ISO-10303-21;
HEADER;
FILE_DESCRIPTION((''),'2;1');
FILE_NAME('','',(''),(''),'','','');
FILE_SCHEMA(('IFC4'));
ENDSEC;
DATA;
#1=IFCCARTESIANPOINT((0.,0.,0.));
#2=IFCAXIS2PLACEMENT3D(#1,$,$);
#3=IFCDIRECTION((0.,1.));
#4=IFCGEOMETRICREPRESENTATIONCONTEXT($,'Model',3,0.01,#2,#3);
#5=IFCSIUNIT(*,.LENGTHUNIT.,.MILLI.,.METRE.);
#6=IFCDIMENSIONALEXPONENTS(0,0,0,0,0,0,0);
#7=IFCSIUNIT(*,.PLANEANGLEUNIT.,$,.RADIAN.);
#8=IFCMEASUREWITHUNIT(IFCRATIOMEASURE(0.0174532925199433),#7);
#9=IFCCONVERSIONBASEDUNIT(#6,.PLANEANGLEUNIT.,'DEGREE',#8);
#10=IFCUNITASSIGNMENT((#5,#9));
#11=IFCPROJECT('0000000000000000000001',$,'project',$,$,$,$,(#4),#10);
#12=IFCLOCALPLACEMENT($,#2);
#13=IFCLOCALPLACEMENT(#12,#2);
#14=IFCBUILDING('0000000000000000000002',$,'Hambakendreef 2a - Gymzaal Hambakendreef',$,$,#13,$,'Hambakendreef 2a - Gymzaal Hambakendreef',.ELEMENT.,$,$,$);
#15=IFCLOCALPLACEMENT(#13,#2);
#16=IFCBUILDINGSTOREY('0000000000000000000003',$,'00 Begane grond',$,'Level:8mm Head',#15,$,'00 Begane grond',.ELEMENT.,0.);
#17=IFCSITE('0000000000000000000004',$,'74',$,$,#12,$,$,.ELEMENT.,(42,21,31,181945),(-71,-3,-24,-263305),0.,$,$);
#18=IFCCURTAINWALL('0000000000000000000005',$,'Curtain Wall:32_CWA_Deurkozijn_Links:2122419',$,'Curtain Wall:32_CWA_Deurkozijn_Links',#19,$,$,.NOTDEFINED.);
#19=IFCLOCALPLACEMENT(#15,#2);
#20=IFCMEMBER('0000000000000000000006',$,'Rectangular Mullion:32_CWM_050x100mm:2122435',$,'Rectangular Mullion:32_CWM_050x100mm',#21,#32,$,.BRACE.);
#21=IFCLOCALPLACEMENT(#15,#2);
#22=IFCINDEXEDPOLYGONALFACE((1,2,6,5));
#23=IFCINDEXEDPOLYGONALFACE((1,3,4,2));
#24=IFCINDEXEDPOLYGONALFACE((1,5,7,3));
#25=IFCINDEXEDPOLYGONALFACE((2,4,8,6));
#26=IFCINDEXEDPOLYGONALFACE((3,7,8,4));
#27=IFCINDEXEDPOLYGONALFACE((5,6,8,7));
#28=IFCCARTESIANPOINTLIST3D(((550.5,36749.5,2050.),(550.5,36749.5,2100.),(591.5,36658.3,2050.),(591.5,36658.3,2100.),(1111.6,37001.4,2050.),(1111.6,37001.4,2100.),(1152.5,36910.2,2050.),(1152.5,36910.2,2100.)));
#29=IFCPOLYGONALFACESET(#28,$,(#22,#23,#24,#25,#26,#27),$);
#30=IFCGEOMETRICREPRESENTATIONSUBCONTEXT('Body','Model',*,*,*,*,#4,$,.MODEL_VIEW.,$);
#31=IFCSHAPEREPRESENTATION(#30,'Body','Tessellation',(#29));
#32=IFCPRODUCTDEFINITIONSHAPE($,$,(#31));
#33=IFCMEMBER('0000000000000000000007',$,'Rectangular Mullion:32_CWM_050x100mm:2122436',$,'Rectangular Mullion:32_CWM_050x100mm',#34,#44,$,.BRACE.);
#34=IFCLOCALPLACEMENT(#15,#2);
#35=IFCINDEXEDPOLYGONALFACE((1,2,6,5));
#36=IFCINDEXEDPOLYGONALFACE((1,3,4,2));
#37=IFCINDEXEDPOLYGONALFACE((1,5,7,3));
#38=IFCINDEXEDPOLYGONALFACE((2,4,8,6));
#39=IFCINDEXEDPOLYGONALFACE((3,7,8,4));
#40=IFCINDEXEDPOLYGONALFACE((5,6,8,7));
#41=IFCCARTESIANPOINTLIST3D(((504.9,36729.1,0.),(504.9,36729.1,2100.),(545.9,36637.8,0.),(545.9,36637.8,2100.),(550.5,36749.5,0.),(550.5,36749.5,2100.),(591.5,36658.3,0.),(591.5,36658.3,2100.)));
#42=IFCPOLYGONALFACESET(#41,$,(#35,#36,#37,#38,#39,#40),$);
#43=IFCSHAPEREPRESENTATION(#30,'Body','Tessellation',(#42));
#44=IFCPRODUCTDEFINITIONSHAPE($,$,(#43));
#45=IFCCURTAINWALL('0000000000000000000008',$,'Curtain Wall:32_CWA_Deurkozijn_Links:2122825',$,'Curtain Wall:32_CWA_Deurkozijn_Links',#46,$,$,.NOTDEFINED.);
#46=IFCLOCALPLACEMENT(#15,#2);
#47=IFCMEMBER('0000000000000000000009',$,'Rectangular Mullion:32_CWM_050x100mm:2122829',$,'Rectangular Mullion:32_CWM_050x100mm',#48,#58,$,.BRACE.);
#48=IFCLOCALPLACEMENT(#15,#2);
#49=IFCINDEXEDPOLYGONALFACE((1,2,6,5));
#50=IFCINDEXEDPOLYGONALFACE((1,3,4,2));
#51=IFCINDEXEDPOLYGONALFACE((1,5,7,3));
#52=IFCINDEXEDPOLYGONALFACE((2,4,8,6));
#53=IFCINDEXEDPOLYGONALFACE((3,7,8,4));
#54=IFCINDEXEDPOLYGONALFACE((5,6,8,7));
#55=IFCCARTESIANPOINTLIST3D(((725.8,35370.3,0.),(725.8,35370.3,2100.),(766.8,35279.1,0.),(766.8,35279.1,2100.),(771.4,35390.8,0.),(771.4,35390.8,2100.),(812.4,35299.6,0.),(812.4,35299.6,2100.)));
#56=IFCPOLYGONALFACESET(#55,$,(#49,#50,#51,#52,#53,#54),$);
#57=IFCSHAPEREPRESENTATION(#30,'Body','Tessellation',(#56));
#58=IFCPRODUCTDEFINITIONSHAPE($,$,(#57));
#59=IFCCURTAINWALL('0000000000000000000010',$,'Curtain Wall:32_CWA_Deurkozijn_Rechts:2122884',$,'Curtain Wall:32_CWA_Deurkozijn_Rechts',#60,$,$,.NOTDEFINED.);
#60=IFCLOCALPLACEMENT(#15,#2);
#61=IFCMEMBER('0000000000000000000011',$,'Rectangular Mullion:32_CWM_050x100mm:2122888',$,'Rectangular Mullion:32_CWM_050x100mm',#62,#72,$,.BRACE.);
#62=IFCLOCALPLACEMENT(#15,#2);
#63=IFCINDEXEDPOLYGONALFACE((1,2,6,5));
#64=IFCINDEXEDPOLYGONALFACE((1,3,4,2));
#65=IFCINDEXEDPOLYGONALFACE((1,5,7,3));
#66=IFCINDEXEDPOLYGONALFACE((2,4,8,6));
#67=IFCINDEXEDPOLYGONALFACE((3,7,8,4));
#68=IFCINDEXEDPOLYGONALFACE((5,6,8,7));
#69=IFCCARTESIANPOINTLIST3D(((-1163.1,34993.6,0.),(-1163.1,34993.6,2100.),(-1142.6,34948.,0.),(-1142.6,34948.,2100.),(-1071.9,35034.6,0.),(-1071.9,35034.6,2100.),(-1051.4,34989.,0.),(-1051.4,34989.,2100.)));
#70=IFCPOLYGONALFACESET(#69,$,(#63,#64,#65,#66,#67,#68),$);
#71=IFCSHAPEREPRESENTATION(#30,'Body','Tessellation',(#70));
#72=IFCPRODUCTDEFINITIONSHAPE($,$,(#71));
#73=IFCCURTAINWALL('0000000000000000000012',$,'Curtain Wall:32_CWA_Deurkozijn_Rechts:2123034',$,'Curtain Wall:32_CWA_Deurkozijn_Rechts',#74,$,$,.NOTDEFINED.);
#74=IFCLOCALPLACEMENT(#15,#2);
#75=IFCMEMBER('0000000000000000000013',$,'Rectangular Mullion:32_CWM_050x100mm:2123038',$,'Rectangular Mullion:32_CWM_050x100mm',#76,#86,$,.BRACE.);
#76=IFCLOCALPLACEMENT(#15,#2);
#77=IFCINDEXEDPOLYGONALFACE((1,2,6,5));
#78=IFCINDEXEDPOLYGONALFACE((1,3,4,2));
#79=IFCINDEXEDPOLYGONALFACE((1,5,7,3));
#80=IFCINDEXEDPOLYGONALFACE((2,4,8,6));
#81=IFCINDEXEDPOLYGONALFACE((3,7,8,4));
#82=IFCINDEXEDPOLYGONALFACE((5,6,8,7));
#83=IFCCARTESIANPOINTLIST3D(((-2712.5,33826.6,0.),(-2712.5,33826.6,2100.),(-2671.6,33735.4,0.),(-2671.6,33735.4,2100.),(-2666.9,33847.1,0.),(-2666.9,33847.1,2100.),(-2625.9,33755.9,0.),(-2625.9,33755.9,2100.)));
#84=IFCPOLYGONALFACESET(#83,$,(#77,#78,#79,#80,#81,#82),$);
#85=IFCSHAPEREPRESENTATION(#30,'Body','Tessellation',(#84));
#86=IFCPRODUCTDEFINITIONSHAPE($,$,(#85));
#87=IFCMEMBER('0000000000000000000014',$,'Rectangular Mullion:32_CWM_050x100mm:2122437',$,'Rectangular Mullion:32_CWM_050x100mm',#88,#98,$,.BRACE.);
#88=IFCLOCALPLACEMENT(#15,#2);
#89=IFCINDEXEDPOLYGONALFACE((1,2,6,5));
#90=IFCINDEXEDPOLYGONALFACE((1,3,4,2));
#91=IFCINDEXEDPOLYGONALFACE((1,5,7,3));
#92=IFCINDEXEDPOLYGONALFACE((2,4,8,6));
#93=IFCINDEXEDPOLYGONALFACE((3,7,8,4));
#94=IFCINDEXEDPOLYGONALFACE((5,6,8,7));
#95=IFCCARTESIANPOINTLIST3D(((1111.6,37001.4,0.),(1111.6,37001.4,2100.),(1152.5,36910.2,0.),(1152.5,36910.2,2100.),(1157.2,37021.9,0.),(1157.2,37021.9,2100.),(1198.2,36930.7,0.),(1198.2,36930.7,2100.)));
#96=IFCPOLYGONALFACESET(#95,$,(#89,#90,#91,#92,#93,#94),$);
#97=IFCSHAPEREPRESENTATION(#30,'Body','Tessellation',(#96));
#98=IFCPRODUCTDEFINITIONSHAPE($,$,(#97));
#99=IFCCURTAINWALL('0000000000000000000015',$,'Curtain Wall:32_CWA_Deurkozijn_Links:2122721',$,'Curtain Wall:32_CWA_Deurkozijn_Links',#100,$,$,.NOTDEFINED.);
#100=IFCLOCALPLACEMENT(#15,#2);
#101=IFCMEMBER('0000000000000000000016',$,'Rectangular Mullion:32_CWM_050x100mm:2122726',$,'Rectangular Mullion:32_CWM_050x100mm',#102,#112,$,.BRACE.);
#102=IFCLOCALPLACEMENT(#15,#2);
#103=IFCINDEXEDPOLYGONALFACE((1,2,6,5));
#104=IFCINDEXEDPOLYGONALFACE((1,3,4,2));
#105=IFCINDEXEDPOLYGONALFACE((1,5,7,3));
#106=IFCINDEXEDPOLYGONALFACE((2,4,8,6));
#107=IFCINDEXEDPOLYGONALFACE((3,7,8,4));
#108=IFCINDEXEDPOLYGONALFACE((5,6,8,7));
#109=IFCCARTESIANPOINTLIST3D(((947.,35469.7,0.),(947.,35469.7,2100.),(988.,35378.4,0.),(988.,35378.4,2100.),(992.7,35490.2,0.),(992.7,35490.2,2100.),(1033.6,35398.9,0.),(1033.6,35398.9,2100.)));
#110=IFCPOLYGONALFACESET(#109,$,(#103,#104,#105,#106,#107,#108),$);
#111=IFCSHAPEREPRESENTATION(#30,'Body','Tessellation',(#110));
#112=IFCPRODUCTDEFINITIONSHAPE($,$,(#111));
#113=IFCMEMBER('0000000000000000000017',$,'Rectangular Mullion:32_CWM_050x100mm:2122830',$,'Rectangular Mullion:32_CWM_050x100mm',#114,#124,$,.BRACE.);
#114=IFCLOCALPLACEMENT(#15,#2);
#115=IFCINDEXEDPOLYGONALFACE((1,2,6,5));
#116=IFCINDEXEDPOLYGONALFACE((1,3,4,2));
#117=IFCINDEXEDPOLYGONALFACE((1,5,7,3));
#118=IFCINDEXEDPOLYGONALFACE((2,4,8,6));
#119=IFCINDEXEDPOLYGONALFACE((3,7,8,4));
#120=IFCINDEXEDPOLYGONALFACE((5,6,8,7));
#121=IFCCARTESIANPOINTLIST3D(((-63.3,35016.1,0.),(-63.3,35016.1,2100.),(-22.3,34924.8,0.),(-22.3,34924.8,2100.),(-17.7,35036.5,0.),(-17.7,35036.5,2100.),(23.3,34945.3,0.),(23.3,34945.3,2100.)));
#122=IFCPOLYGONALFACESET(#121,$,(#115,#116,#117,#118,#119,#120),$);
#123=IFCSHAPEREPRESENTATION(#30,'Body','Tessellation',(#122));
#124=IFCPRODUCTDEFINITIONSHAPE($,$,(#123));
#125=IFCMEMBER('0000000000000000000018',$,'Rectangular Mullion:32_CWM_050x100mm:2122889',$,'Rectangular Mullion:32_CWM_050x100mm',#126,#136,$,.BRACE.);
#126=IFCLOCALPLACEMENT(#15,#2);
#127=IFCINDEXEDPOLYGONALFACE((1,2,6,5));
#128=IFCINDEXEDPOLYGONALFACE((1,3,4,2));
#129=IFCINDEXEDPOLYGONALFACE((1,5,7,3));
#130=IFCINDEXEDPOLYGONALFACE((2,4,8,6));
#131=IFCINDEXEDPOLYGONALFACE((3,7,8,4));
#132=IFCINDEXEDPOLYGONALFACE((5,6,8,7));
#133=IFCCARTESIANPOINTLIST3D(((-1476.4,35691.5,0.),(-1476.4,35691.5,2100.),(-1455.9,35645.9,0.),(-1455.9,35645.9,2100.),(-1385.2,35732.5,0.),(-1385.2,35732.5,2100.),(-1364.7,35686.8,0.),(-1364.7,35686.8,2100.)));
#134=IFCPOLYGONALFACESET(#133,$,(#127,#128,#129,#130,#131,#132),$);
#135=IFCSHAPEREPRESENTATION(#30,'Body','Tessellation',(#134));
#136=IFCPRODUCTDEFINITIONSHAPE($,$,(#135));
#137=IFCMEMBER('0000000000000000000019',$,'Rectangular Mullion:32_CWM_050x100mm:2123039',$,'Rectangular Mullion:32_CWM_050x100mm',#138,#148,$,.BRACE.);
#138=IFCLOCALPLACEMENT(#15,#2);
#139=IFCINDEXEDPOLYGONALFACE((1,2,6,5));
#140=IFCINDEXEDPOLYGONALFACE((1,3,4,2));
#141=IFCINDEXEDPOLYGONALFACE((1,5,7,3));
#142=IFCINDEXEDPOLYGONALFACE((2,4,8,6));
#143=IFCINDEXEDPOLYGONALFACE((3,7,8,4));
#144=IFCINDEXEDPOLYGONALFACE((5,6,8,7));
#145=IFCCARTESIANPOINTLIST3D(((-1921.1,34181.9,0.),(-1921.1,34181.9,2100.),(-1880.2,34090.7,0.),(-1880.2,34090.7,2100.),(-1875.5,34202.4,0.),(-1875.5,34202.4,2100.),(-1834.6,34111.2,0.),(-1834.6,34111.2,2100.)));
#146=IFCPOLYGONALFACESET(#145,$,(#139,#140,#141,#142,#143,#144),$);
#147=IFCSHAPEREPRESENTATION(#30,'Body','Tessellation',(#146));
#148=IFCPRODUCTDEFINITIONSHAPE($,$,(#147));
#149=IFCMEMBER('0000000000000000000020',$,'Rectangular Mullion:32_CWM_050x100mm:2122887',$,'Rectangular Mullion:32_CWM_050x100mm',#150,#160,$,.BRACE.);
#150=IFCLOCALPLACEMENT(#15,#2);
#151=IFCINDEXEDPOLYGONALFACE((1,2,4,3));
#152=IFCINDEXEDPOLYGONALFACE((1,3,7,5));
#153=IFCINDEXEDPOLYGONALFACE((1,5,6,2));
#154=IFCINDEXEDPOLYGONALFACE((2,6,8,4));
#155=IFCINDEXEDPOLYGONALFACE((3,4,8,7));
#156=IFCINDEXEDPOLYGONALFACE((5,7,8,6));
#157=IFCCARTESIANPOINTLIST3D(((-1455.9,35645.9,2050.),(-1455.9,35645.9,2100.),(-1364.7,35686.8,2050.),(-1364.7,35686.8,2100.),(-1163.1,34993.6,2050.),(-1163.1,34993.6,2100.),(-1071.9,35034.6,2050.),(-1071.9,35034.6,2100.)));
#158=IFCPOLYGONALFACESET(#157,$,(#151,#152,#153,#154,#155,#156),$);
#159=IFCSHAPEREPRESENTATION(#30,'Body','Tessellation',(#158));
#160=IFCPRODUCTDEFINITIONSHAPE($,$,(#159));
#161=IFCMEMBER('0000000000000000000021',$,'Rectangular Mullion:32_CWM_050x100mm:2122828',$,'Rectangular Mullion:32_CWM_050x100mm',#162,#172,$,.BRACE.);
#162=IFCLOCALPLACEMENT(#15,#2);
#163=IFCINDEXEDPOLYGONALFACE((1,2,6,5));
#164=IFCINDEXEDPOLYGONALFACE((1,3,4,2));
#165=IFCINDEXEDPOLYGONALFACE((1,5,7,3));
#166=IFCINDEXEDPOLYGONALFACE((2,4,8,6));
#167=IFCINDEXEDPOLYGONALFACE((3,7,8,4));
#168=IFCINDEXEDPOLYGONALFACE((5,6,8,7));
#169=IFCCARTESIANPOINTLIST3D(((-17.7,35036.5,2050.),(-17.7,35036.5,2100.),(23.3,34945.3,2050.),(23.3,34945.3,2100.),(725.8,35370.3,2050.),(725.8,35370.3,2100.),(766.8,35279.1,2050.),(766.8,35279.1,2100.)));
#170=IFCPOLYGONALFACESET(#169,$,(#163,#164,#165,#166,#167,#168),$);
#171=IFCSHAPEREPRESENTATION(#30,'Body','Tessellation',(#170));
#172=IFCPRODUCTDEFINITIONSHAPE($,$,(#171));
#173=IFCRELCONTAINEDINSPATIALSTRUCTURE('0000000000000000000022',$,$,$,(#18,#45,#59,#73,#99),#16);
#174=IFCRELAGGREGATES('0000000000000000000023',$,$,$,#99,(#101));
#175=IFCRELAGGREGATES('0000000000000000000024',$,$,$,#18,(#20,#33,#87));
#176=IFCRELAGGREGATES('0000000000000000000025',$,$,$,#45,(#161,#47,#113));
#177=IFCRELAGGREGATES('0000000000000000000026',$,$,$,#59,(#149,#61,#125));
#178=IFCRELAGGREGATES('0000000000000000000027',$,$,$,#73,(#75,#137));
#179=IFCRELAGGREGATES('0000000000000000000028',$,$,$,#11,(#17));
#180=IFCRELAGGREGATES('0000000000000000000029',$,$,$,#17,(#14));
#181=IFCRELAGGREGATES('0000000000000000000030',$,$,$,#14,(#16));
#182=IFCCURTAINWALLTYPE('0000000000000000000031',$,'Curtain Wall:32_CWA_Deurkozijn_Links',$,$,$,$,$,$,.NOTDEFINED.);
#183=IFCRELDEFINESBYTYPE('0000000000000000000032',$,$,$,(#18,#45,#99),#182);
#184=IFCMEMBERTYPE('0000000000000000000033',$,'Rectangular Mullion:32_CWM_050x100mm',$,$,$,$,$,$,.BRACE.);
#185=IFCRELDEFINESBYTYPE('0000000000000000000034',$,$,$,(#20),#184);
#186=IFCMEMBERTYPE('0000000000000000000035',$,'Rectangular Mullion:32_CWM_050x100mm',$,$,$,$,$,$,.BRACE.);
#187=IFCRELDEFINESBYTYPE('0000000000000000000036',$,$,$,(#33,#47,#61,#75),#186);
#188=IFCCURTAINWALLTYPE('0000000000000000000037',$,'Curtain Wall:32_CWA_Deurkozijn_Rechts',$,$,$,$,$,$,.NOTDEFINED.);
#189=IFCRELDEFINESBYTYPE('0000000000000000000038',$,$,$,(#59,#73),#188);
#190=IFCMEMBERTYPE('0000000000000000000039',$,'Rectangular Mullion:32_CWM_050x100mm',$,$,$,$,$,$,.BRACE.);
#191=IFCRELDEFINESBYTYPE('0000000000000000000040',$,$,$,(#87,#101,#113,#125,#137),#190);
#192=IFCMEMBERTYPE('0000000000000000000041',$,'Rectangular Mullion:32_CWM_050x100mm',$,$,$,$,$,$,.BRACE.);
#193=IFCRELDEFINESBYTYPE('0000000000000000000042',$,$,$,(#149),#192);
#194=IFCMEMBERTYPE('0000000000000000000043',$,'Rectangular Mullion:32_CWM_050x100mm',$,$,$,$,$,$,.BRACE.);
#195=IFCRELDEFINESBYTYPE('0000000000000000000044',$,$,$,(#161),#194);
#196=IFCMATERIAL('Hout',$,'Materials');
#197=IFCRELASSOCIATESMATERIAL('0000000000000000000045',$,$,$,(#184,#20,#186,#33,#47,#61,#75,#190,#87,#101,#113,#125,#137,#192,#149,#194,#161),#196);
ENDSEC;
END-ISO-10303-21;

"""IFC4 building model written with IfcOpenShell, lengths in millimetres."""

from ifc_helpers import new_model, entity, si_unit, converted_unit, direction, frame, origin, place, context, subcontext, project, spatial, indexed_curve, outline, extrude, source, transform, mapped, material, type_object, type_shapes, element, aggregate, save


model = new_model("IFC4")

# Units and contexts
model_context = context("Model", 3, precision=0.01, world=origin(), true_north=direction((0.0, 1.0)))
body_context = subcontext(model_context, "Body", "Model", "MODEL_VIEW")
ifc_project = project(units=[si_unit("LENGTHUNIT", "METRE", prefix="MILLI"), converted_unit("PLANEANGLEUNIT", "DEGREE", entity("IfcRatioMeasure", 0.0174532925199433), si_unit("PLANEANGLEUNIT", "RADIAN"), dimensions=[0, 0, 0, 0, 0, 0, 0])], contexts=[model_context])

# Site, building, storey
site_placement = place(None, origin())
site = spatial("IfcSite", under=ifc_project, at=site_placement, Name="74", CompositionType="ELEMENT", RefLatitude=(42, 21, 31, 181945), RefLongitude=(-71, -3, -24, -263305), RefElevation=0.0)
building_placement = place(site_placement, origin())
building = spatial("IfcBuilding", under=site, at=building_placement, Name="Hambakendreef 2a - Gymzaal Hambakendreef", LongName="Hambakendreef 2a - Gymzaal Hambakendreef", CompositionType="ELEMENT")
storey_placement = place(building_placement, origin())
storey = spatial("IfcBuildingStorey", under=building, at=storey_placement, Name="00 Begane grond", ObjectType="Level:8mm Head", LongName="00 Begane grond", CompositionType="ELEMENT", Elevation=0.0)

# Curtain wall, members
curtain_wall_type_1 = type_object("IfcCurtainWallType", Name="Curtain Wall:32_CWA_Deurkozijn_Links", PredefinedType="NOTDEFINED")
curtain_wall_1_placement = place(storey_placement, origin())
curtain_wall_1 = element("IfcCurtainWall", 1, at=curtain_wall_1_placement, inside=storey, type_object=curtain_wall_type_1, Name="Curtain Wall:32_CWA_Deurkozijn_Links:2122419", ObjectType="Curtain Wall:32_CWA_Deurkozijn_Links", PredefinedType="NOTDEFINED")
ifc_material_1 = material(Name="Hout", Category="Materials")
member_type_1 = type_object("IfcMemberType", Name="Rectangular Mullion:32_CWM_050x100mm", PredefinedType="BRACE", material=ifc_material_1)
shared_shape_1 = source(origin(), body_context, "Body", "SweptSolid", [
    extrude(outline(indexed_curve([(-50.0, -25.0), (50.0, -25.0), (50.0, 25.0), (-50.0, 25.0), (-50.0, -25.0)], self_intersect=False)), frame((-25.0, 0.0, -615.0), z_axis=(0.0, 0.0, 1.0), x_axis=(0.0, -1.0, 0.0)), (0.0, 0.0, 1.0), 615.0),
])
type_shapes(member_type_1, [shared_shape_1])
member_1_placement = place(storey_placement, frame((571.0, 36703.9, 2100.0), z_axis=(-0.91227, -0.40959, 0.0), x_axis=(0.0, 0.0, 1.0)))
member_1 = element("IfcMember", 2, at=member_1_placement, type_object=member_type_1, material=ifc_material_1, Name="Rectangular Mullion:32_CWM_050x100mm:2122435", ObjectType="Rectangular Mullion:32_CWM_050x100mm", PredefinedType="BRACE", context=body_context, shape_type="MappedRepresentation", body=[
    mapped(shared_shape_1, transform((0.0, 0.0, 0.0), scale=1.0)),
])
member_type_2 = type_object("IfcMemberType", Name="Rectangular Mullion:32_CWM_050x100mm", PredefinedType="BRACE", material=ifc_material_1)
shared_shape_2 = source(origin(), body_context, "Body", "SweptSolid", [
    extrude(outline(indexed_curve([(-50.0, -25.0), (50.0, -25.0), (50.0, 25.0), (-50.0, 25.0), (-50.0, -25.0)], self_intersect=False)), frame((-25.0, 0.0, -2100.0), z_axis=(0.0, 0.0, 1.0), x_axis=(0.0, -1.0, 0.0)), (0.0, 0.0, 1.0), 2100.0),
])
type_shapes(member_type_2, [shared_shape_2])
member_2_placement = place(storey_placement, frame((525.4, 36683.5, 0.0), z_axis=(0.0, 0.0, -1.0), x_axis=(-0.91227, -0.40959, 0.0)))
member_2 = element("IfcMember", 3, at=member_2_placement, type_object=member_type_2, material=ifc_material_1, Name="Rectangular Mullion:32_CWM_050x100mm:2122436", ObjectType="Rectangular Mullion:32_CWM_050x100mm", PredefinedType="BRACE", context=body_context, shape_type="MappedRepresentation", body=[
    mapped(shared_shape_2, transform((0.0, 0.0, 0.0), scale=1.0)),
])

# Curtain walls, members
curtain_wall_2_placement = place(storey_placement, origin())
curtain_wall_2 = element("IfcCurtainWall", 4, at=curtain_wall_2_placement, inside=storey, type_object=curtain_wall_type_1, Name="Curtain Wall:32_CWA_Deurkozijn_Links:2122825", ObjectType="Curtain Wall:32_CWA_Deurkozijn_Links", PredefinedType="NOTDEFINED")
member_3_placement = place(storey_placement, frame((791.9, 35345.2, 0.0), z_axis=(0.0, 0.0, -1.0), x_axis=(0.91227, 0.40959, 0.0)))
member_3 = element("IfcMember", 5, at=member_3_placement, type_object=member_type_2, material=ifc_material_1, Name="Rectangular Mullion:32_CWM_050x100mm:2122829", ObjectType="Rectangular Mullion:32_CWM_050x100mm", PredefinedType="BRACE", context=body_context, shape_type="MappedRepresentation", body=[
    mapped(shared_shape_2, transform((0.0, 0.0, 0.0), scale=1.0)),
])
curtain_wall_type_2 = type_object("IfcCurtainWallType", Name="Curtain Wall:32_CWA_Deurkozijn_Rechts", PredefinedType="NOTDEFINED")
curtain_wall_3_placement = place(storey_placement, origin())
curtain_wall_3 = element("IfcCurtainWall", 6, at=curtain_wall_3_placement, inside=storey, type_object=curtain_wall_type_2, Name="Curtain Wall:32_CWA_Deurkozijn_Rechts:2122884", ObjectType="Curtain Wall:32_CWA_Deurkozijn_Rechts", PredefinedType="NOTDEFINED")
member_4_placement = place(storey_placement, frame((-1097.0, 34968.5, 0.0), z_axis=(0.0, 0.0, -1.0), x_axis=(0.40959, -0.91227, 0.0)))
member_4 = element("IfcMember", 7, at=member_4_placement, type_object=member_type_2, material=ifc_material_1, Name="Rectangular Mullion:32_CWM_050x100mm:2122888", ObjectType="Rectangular Mullion:32_CWM_050x100mm", PredefinedType="BRACE", context=body_context, shape_type="MappedRepresentation", body=[
    mapped(shared_shape_2, transform((0.0, 0.0, 0.0), scale=1.0)),
])
curtain_wall_4_placement = place(storey_placement, origin())
curtain_wall_4 = element("IfcCurtainWall", 8, at=curtain_wall_4_placement, inside=storey, type_object=curtain_wall_type_2, Name="Curtain Wall:32_CWA_Deurkozijn_Rechts:2123034", ObjectType="Curtain Wall:32_CWA_Deurkozijn_Rechts", PredefinedType="NOTDEFINED")
member_5_placement = place(storey_placement, frame((-2692.0, 33781.0, 0.0), z_axis=(0.0, 0.0, -1.0), x_axis=(-0.91227, -0.40959, 0.0)))
member_5 = element("IfcMember", 9, at=member_5_placement, type_object=member_type_2, material=ifc_material_1, Name="Rectangular Mullion:32_CWM_050x100mm:2123038", ObjectType="Rectangular Mullion:32_CWM_050x100mm", PredefinedType="BRACE", context=body_context, shape_type="MappedRepresentation", body=[
    mapped(shared_shape_2, transform((0.0, 0.0, 0.0), scale=1.0)),
])

# Member
member_type_3 = type_object("IfcMemberType", Name="Rectangular Mullion:32_CWM_050x100mm", PredefinedType="BRACE", material=ifc_material_1)
shared_shape_3 = source(origin(), body_context, "Body", "SweptSolid", [
    extrude(outline(indexed_curve([(-50.0, -25.0), (50.0, -25.0), (50.0, 25.0), (-50.0, 25.0), (-50.0, -25.0)], self_intersect=False)), frame((-25.0, 0.0, -2100.0), z_axis=(0.0, 0.0, 1.0), x_axis=(0.0, -1.0, 0.0)), (0.0, 0.0, 1.0), 2100.0),
])
type_shapes(member_type_3, [shared_shape_3])
member_6_placement = place(storey_placement, frame((1177.7, 36976.3, 2100.0), z_axis=(0.0, 0.0, 1.0), x_axis=(0.91227, 0.40959, 0.0)))
member_6 = element("IfcMember", 10, at=member_6_placement, type_object=member_type_3, material=ifc_material_1, Name="Rectangular Mullion:32_CWM_050x100mm:2122437", ObjectType="Rectangular Mullion:32_CWM_050x100mm", PredefinedType="BRACE", context=body_context, shape_type="MappedRepresentation", body=[
    mapped(shared_shape_3, transform((0.0, 0.0, 0.0), scale=1.0)),
])

# Curtain wall, member
curtain_wall_5_placement = place(storey_placement, origin())
curtain_wall_5 = element("IfcCurtainWall", 11, at=curtain_wall_5_placement, inside=storey, type_object=curtain_wall_type_1, Name="Curtain Wall:32_CWA_Deurkozijn_Links:2122721", ObjectType="Curtain Wall:32_CWA_Deurkozijn_Links", PredefinedType="NOTDEFINED")
member_7_placement = place(storey_placement, frame((967.5, 35424.1, 2100.0), z_axis=(0.0, 0.0, 1.0), x_axis=(-0.91227, -0.40959, 0.0)))
member_7 = element("IfcMember", 12, at=member_7_placement, type_object=member_type_3, material=ifc_material_1, Name="Rectangular Mullion:32_CWM_050x100mm:2122726", ObjectType="Rectangular Mullion:32_CWM_050x100mm", PredefinedType="BRACE", context=body_context, shape_type="MappedRepresentation", body=[
    mapped(shared_shape_3, transform((0.0, 0.0, 0.0), scale=1.0)),
])
aggregate(curtain_wall_5, [member_7])

# Members
member_8_placement = place(storey_placement, frame((-42.8, 34970.4, 2100.0), z_axis=(0.0, 0.0, 1.0), x_axis=(-0.91227, -0.40959, 0.0)))
member_8 = element("IfcMember", 13, at=member_8_placement, type_object=member_type_3, material=ifc_material_1, Name="Rectangular Mullion:32_CWM_050x100mm:2122830", ObjectType="Rectangular Mullion:32_CWM_050x100mm", PredefinedType="BRACE", context=body_context, shape_type="MappedRepresentation", body=[
    mapped(shared_shape_3, transform((0.0, 0.0, 0.0), scale=1.0)),
])
member_9_placement = place(storey_placement, frame((-1430.8, 35712.0, 2100.0), z_axis=(0.0, 0.0, 1.0), x_axis=(-0.40959, 0.91227, 0.0)))
member_9 = element("IfcMember", 14, at=member_9_placement, type_object=member_type_3, material=ifc_material_1, Name="Rectangular Mullion:32_CWM_050x100mm:2122889", ObjectType="Rectangular Mullion:32_CWM_050x100mm", PredefinedType="BRACE", context=body_context, shape_type="MappedRepresentation", body=[
    mapped(shared_shape_3, transform((0.0, 0.0, 0.0), scale=1.0)),
])
member_10_placement = place(storey_placement, frame((-1855.0, 34156.8, 2100.0), z_axis=(0.0, 0.0, 1.0), x_axis=(0.91227, 0.40959, 0.0)))
member_10 = element("IfcMember", 15, at=member_10_placement, type_object=member_type_3, material=ifc_material_1, Name="Rectangular Mullion:32_CWM_050x100mm:2123039", ObjectType="Rectangular Mullion:32_CWM_050x100mm", PredefinedType="BRACE", context=body_context, shape_type="MappedRepresentation", body=[
    mapped(shared_shape_3, transform((0.0, 0.0, 0.0), scale=1.0)),
])
member_type_4 = type_object("IfcMemberType", Name="Rectangular Mullion:32_CWM_050x100mm", PredefinedType="BRACE", material=ifc_material_1)
shared_shape_4 = source(origin(), body_context, "Body", "SweptSolid", [
    extrude(outline(indexed_curve([(-50.0, -25.0), (50.0, -25.0), (50.0, 25.0), (-50.0, 25.0), (-50.0, -25.0)], self_intersect=False)), frame((-25.0, 0.0, -715.0), z_axis=(0.0, 0.0, 1.0), x_axis=(0.0, -1.0, 0.0)), (0.0, 0.0, 1.0), 715.0),
])
type_shapes(member_type_4, [shared_shape_4])
member_11_placement = place(storey_placement, frame((-1117.5, 35014.1, 2100.0), z_axis=(0.40959, -0.91227, 0.0), x_axis=(0.0, 0.0, 1.0)))
member_11 = element("IfcMember", 16, at=member_11_placement, type_object=member_type_4, material=ifc_material_1, Name="Rectangular Mullion:32_CWM_050x100mm:2122887", ObjectType="Rectangular Mullion:32_CWM_050x100mm", PredefinedType="BRACE", context=body_context, shape_type="MappedRepresentation", body=[
    mapped(shared_shape_4, transform((0.0, 0.0, 0.0), scale=1.0)),
])
member_type_5 = type_object("IfcMemberType", Name="Rectangular Mullion:32_CWM_050x100mm", PredefinedType="BRACE", material=ifc_material_1)
shared_shape_5 = source(origin(), body_context, "Body", "SweptSolid", [
    extrude(outline(indexed_curve([(-50.0, -25.0), (50.0, -25.0), (50.0, 25.0), (-50.0, 25.0), (-50.0, -25.0)], self_intersect=False)), frame((-25.0, 0.0, -815.0), z_axis=(0.0, 0.0, 1.0), x_axis=(0.0, -1.0, 0.0)), (0.0, 0.0, 1.0), 815.0),
])
type_shapes(member_type_5, [shared_shape_5])
member_12_placement = place(storey_placement, frame((746.3, 35324.7, 2100.0), z_axis=(0.91227, 0.40959, 0.0), x_axis=(0.0, 0.0, 1.0)))
member_12 = element("IfcMember", 17, at=member_12_placement, type_object=member_type_5, material=ifc_material_1, Name="Rectangular Mullion:32_CWM_050x100mm:2122828", ObjectType="Rectangular Mullion:32_CWM_050x100mm", PredefinedType="BRACE", context=body_context, shape_type="MappedRepresentation", body=[
    mapped(shared_shape_5, transform((0.0, 0.0, 0.0), scale=1.0)),
])

aggregate(curtain_wall_1, [member_1, member_2, member_6])
aggregate(curtain_wall_2, [member_12, member_3, member_8])
aggregate(curtain_wall_3, [member_11, member_4, member_9])
aggregate(curtain_wall_4, [member_5, member_10])

save(model, "model.ifc")
